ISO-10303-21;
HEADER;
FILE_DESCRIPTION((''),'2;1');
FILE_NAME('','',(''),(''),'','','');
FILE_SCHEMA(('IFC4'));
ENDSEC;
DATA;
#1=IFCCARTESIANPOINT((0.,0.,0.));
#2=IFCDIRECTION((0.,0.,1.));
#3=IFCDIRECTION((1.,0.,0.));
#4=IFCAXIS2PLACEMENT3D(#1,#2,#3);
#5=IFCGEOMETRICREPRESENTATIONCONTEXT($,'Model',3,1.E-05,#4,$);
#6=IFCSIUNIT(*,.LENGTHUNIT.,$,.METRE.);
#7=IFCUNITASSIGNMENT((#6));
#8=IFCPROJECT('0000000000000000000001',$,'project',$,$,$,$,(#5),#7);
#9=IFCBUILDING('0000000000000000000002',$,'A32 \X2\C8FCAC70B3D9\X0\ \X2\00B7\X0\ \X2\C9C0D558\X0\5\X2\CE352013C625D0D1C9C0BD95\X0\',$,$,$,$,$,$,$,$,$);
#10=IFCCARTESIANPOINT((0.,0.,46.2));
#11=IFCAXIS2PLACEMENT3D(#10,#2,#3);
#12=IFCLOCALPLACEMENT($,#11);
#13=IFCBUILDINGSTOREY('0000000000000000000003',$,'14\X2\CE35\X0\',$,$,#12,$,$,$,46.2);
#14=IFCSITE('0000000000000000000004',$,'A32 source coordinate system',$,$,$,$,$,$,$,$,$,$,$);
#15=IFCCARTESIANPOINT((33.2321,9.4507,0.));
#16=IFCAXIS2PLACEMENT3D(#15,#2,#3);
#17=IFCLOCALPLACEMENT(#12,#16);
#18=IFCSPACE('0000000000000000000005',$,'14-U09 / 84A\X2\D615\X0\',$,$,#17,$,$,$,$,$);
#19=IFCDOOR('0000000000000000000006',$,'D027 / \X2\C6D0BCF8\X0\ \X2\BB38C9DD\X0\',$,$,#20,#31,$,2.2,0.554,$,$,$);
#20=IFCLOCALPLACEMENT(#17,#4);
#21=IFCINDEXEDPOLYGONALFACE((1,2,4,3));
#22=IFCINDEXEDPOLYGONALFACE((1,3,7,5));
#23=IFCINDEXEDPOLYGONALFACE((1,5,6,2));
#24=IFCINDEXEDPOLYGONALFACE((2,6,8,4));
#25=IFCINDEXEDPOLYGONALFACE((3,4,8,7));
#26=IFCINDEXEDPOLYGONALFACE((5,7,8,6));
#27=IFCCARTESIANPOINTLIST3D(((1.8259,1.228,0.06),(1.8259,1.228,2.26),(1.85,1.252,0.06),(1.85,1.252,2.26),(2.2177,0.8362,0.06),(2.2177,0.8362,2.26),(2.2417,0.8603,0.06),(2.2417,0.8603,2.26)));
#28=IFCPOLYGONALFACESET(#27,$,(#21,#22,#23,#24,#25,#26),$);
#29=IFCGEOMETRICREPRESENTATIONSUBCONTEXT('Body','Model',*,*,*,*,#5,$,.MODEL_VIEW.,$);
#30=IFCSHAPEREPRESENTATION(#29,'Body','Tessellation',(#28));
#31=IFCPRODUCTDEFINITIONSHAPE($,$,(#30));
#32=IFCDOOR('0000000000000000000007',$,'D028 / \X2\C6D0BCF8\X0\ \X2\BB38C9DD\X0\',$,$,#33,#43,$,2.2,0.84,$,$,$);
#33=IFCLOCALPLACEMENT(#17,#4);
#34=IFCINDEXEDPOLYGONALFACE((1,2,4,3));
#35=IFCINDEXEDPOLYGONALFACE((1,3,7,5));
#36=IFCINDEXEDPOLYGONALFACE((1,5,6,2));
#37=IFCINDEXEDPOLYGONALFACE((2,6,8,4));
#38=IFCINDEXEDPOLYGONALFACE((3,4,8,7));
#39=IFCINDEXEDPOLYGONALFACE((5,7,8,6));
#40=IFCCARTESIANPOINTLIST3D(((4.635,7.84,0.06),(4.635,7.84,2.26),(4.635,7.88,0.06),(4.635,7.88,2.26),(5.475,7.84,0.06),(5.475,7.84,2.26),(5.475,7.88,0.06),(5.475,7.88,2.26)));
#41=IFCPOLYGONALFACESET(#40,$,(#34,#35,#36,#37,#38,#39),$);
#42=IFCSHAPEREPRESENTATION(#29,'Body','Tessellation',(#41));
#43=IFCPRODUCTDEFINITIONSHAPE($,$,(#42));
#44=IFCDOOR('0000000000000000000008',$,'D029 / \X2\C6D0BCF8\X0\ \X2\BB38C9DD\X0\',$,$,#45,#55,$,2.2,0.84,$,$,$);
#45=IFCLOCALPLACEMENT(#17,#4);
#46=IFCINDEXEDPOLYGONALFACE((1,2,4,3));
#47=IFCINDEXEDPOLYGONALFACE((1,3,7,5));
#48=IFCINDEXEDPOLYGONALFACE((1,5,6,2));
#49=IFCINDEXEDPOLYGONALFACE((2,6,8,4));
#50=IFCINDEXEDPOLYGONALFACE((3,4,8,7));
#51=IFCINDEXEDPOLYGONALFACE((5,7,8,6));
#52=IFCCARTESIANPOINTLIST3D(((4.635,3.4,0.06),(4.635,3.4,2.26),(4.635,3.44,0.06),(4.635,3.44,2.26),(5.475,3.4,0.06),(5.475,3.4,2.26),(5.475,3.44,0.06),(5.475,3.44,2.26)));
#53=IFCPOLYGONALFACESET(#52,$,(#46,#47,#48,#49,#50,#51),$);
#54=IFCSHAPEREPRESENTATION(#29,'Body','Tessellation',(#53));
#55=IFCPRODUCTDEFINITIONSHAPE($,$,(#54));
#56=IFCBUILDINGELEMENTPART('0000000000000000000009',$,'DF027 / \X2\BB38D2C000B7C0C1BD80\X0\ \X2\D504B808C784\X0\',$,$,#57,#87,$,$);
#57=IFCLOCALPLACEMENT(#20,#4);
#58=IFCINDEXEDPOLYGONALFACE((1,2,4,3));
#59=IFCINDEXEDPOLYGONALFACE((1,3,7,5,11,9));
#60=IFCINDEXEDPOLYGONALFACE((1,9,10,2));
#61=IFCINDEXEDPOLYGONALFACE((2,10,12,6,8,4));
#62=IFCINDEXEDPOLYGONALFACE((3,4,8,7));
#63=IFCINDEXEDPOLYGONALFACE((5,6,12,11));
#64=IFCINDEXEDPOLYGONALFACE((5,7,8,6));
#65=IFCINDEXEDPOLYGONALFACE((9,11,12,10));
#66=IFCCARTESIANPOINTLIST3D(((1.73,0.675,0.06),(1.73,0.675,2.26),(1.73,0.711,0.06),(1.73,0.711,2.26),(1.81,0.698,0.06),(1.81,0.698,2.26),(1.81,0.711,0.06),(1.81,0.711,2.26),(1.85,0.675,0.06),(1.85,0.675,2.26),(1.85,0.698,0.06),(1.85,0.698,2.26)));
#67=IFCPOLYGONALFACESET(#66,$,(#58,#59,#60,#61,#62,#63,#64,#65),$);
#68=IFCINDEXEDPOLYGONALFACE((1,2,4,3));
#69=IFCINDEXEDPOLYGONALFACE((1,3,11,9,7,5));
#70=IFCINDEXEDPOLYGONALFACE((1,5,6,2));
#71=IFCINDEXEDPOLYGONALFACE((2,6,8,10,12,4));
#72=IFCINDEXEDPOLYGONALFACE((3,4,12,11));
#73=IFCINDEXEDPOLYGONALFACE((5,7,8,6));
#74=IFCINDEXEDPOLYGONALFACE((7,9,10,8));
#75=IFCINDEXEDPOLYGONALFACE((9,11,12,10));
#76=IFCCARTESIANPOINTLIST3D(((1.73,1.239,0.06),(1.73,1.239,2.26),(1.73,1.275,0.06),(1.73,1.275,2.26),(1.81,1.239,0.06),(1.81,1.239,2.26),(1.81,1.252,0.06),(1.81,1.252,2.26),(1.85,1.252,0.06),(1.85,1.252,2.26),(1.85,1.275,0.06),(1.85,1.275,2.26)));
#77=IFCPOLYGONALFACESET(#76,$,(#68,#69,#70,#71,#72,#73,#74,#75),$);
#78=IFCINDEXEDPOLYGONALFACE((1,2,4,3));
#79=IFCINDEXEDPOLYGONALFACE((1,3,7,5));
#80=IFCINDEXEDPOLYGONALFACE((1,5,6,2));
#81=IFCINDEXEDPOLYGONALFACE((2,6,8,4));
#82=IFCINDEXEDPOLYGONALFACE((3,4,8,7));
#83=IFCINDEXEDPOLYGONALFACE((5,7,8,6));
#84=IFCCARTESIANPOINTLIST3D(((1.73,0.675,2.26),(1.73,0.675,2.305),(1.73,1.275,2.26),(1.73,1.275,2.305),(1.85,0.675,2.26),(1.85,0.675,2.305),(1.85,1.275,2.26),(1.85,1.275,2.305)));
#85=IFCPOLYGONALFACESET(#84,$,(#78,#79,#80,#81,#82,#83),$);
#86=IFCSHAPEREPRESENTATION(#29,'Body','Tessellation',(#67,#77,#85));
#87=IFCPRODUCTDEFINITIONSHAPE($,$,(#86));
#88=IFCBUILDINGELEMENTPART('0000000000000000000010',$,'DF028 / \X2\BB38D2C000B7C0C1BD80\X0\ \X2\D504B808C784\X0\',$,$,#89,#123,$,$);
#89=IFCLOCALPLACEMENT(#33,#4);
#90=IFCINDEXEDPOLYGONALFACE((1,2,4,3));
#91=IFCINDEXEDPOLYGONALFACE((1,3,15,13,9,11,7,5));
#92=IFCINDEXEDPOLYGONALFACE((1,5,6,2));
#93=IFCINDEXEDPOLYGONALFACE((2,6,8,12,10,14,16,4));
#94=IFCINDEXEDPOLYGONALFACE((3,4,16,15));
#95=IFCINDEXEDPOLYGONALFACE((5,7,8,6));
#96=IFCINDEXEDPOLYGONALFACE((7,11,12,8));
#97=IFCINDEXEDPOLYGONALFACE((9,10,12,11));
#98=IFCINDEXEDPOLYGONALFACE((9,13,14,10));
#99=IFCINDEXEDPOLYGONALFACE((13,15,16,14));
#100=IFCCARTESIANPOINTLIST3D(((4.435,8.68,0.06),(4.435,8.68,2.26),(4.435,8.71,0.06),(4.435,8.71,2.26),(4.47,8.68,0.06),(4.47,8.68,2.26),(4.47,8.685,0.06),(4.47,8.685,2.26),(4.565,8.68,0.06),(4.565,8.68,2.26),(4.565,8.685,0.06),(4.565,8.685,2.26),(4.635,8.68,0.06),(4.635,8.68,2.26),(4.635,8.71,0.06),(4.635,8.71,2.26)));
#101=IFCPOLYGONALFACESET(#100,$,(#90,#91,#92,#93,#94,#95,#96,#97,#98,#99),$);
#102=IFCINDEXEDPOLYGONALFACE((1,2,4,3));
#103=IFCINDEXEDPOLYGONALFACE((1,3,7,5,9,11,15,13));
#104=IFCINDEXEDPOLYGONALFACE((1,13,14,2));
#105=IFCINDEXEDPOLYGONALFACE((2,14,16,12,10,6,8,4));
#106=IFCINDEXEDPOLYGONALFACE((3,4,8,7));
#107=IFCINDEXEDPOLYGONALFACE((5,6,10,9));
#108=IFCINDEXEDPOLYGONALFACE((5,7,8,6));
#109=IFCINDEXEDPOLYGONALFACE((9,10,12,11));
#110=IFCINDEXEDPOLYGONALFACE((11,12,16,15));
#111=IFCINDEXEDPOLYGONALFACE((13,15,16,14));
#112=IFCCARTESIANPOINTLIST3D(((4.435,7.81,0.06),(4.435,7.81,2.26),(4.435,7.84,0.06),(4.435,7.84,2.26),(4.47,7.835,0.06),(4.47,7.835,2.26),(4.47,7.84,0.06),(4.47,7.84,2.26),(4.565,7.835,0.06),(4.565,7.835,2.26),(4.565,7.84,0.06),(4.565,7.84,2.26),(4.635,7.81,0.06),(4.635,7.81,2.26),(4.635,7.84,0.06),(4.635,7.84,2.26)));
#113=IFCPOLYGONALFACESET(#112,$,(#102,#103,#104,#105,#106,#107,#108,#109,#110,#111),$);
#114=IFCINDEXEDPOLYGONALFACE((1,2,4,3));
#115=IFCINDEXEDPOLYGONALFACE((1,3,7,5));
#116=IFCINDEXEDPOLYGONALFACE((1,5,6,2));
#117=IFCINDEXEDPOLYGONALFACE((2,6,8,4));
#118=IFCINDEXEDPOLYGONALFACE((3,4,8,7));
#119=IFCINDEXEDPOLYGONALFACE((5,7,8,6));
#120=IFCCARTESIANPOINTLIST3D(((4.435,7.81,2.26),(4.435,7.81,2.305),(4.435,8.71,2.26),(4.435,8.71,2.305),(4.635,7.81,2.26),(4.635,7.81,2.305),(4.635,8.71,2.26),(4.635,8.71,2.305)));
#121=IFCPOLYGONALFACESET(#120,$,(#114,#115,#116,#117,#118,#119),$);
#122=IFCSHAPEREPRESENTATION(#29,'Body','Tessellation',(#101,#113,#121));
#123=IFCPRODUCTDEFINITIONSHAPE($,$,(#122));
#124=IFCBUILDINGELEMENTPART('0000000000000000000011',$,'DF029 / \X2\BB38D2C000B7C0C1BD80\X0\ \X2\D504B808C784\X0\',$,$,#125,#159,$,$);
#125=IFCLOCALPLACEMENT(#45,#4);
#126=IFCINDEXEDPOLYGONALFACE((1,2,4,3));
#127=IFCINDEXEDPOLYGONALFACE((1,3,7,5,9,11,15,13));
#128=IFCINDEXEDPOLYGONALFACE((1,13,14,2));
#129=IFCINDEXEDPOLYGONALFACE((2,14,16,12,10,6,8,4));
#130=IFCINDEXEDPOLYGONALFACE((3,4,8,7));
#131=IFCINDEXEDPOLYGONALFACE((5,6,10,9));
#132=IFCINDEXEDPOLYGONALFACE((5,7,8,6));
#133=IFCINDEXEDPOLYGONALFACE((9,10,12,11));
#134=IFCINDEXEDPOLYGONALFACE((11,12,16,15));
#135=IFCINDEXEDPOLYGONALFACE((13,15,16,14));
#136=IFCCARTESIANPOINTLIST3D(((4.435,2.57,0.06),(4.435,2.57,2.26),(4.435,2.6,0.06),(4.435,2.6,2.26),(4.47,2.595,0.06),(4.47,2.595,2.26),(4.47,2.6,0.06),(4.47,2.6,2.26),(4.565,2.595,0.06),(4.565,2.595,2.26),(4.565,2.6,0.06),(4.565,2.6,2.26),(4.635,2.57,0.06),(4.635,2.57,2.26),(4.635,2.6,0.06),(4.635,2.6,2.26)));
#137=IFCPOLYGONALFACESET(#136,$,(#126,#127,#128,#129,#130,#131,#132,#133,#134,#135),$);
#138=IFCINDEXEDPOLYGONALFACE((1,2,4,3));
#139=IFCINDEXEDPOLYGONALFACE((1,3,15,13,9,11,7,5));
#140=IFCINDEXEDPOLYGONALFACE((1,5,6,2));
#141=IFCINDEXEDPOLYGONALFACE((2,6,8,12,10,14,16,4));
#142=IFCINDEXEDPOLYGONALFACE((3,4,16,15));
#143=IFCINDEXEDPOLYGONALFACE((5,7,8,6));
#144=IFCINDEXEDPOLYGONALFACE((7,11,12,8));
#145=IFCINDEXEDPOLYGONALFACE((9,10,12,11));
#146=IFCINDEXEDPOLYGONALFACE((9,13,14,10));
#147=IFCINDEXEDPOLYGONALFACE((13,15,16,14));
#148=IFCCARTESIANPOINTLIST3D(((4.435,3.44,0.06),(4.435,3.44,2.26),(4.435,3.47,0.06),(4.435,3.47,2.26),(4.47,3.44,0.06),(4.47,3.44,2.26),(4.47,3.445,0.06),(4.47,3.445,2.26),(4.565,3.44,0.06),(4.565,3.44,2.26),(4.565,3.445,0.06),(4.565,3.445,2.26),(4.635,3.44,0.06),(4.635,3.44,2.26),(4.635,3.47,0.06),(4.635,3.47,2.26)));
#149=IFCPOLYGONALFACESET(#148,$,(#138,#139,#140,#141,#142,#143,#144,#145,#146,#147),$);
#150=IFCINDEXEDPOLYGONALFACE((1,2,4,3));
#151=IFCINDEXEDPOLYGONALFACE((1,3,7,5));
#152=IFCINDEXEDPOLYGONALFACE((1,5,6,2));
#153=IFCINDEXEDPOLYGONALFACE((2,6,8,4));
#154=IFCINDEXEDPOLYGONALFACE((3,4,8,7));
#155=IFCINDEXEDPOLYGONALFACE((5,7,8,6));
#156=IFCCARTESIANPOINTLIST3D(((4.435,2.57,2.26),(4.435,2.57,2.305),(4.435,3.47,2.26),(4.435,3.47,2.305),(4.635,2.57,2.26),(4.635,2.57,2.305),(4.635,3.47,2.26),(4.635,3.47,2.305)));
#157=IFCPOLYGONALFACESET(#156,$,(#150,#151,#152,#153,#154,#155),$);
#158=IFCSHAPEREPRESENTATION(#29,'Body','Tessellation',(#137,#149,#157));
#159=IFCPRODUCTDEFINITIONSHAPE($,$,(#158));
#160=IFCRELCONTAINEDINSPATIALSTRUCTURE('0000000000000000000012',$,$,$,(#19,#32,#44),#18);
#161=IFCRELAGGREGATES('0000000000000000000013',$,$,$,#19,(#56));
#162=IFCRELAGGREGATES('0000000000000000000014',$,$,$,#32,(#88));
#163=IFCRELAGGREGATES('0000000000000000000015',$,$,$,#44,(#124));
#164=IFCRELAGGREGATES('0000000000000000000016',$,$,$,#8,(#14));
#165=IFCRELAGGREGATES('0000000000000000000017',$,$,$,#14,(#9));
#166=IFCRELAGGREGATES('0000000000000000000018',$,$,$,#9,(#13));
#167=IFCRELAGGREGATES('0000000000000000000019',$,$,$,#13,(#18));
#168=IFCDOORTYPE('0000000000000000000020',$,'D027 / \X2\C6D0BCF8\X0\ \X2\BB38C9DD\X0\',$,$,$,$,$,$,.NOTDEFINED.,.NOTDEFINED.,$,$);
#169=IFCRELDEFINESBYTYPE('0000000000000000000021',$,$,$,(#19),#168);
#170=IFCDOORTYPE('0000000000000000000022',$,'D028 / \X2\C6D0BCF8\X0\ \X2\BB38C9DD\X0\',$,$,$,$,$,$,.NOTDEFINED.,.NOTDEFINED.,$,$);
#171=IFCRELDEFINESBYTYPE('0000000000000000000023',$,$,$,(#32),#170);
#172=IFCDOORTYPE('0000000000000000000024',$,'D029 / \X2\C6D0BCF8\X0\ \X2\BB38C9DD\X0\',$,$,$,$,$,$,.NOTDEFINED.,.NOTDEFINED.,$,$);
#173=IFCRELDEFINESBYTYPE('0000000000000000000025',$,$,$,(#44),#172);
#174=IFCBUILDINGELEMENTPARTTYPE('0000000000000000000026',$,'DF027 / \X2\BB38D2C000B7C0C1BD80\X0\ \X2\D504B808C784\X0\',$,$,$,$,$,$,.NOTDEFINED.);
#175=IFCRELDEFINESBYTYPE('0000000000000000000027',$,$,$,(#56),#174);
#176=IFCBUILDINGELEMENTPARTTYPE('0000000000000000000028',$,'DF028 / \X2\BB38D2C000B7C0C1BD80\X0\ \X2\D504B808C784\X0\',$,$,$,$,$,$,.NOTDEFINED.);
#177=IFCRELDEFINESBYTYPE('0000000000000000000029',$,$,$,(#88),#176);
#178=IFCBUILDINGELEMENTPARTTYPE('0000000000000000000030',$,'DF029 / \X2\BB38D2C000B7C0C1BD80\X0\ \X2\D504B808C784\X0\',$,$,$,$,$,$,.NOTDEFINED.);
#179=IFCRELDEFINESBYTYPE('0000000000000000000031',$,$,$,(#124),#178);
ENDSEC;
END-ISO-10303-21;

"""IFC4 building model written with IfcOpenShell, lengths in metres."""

from ifc_helpers import new_model, si_unit, frame, origin, origin_with_axes, place, context, subcontext, project, spatial, polyline, outline, extrude, source, transform, mapped, type_object, type_shapes, element, aggregate, save


model = new_model("IFC4")

# Units and contexts
model_context = context("Model", 3, precision=1e-05, world=origin_with_axes())
body_context = subcontext(model_context, "Body", "Model", "MODEL_VIEW")
ifc_project = project(units=[si_unit("LENGTHUNIT", "METRE")], contexts=[model_context])

# Site, building, storey, space
storey_placement = place(None, frame((0.0, 0.0, 46.2), z_axis=(0.0, 0.0, 1.0), x_axis=(1.0, 0.0, 0.0)))
space_placement = place(storey_placement, frame((33.2321, 9.4507, 0.0), z_axis=(0.0, 0.0, 1.0), x_axis=(1.0, 0.0, 0.0)))
site = spatial("IfcSite", under=ifc_project, Name="A32 source coordinate system")
building = spatial("IfcBuilding", under=site, Name="A32 주거동 · 지하5층–옥탑지붕")
storey = spatial("IfcBuildingStorey", under=building, at=storey_placement, Name="14층", Elevation=46.2)
space = spatial("IfcSpace", under=storey, at=space_placement, Name="14-U09 / 84A형")

# Doors
door_type_1 = type_object("IfcDoorType", Name="D027 / 원본 문짝", OperationType="NOTDEFINED", PredefinedType="NOTDEFINED")
shared_shape_1 = source(origin(), body_context, "Body", "SweptSolid", [
    extrude(outline(polyline([(1.85, 1.252), (2.2417, 0.8603), (2.2177, 0.8362), (1.8259, 1.228), (1.85, 1.252)])), frame((0.0, 0.0, 0.06)), (0.0, 0.0, 1.0), 2.2),
])
type_shapes(door_type_1, [shared_shape_1])
door_1_placement = place(space_placement, origin_with_axes())
door_1 = element("IfcDoor", 1, at=door_1_placement, inside=space, type_object=door_type_1, Name="D027 / 원본 문짝", OverallHeight=2.2, OverallWidth=0.554, context=body_context, shape_type="MappedRepresentation", body=[
    mapped(shared_shape_1, transform((0.0, 0.0, 0.0), scale=1.0)),
])
door_type_2 = type_object("IfcDoorType", Name="D028 / 원본 문짝", OperationType="NOTDEFINED", PredefinedType="NOTDEFINED")
shared_shape_2 = source(origin(), body_context, "Body", "SweptSolid", [
    extrude(outline(polyline([(5.475, 7.88), (5.475, 7.84), (4.635, 7.84), (4.635, 7.88), (5.475, 7.88)])), frame((0.0, 0.0, 0.06)), (0.0, 0.0, 1.0), 2.2),
])
type_shapes(door_type_2, [shared_shape_2])
door_2_placement = place(space_placement, origin_with_axes())
door_2 = element("IfcDoor", 2, at=door_2_placement, inside=space, type_object=door_type_2, Name="D028 / 원본 문짝", OverallHeight=2.2, OverallWidth=0.84, context=body_context, shape_type="MappedRepresentation", body=[
    mapped(shared_shape_2, transform((0.0, 0.0, 0.0), scale=1.0)),
])
door_type_3 = type_object("IfcDoorType", Name="D029 / 원본 문짝", OperationType="NOTDEFINED", PredefinedType="NOTDEFINED")
shared_shape_3 = source(origin(), body_context, "Body", "SweptSolid", [
    extrude(outline(polyline([(4.635, 3.44), (5.475, 3.44), (5.475, 3.4), (4.635, 3.4), (4.635, 3.44)])), frame((0.0, 0.0, 0.06)), (0.0, 0.0, 1.0), 2.2),
])
type_shapes(door_type_3, [shared_shape_3])
door_3_placement = place(space_placement, origin_with_axes())
door_3 = element("IfcDoor", 3, at=door_3_placement, inside=space, type_object=door_type_3, Name="D029 / 원본 문짝", OverallHeight=2.2, OverallWidth=0.84, context=body_context, shape_type="MappedRepresentation", body=[
    mapped(shared_shape_3, transform((0.0, 0.0, 0.0), scale=1.0)),
])

# Building element parts
building_element_part_type_1 = type_object("IfcBuildingElementPartType", Name="DF027 / 문틀·상부 프레임", PredefinedType="NOTDEFINED")
shared_shape_4 = source(origin(), body_context, "Body", "SweptSolid", [
    extrude(outline(polyline([(1.73, 0.711), (1.81, 0.711), (1.81, 0.698), (1.85, 0.698), (1.85, 0.675), (1.73, 0.675), (1.73, 0.711)])), frame((0.0, 0.0, 0.06)), (0.0, 0.0, 1.0), 2.2),
    extrude(outline(polyline([(1.85, 1.275), (1.85, 1.252), (1.81, 1.252), (1.81, 1.239), (1.73, 1.239), (1.73, 1.275), (1.85, 1.275)])), frame((0.0, 0.0, 0.06)), (0.0, 0.0, 1.0), 2.2),
    extrude(outline(polyline([(1.73, 0.675), (1.73, 1.275), (1.85, 1.275), (1.85, 0.675), (1.73, 0.675)])), frame((0.0, 0.0, 2.26)), (0.0, 0.0, 1.0), 0.045),
])
type_shapes(building_element_part_type_1, [shared_shape_4])
building_element_part_1_placement = place(door_1_placement, origin_with_axes())
building_element_part_1 = element("IfcBuildingElementPart", 4, at=building_element_part_1_placement, type_object=building_element_part_type_1, Name="DF027 / 문틀·상부 프레임", context=body_context, shape_type="MappedRepresentation", body=[
    mapped(shared_shape_4, transform((0.0, 0.0, 0.0), scale=1.0)),
])
aggregate(door_1, [building_element_part_1])
building_element_part_type_2 = type_object("IfcBuildingElementPartType", Name="DF028 / 문틀·상부 프레임", PredefinedType="NOTDEFINED")
shared_shape_5 = source(origin(), body_context, "Body", "SweptSolid", [
    extrude(outline(polyline([(4.635, 8.68), (4.565, 8.68), (4.565, 8.685), (4.47, 8.685), (4.47, 8.68), (4.435, 8.68), (4.435, 8.71), (4.635, 8.71), (4.635, 8.68)])), frame((0.0, 0.0, 0.06)), (0.0, 0.0, 1.0), 2.2),
    extrude(outline(polyline([(4.435, 7.81), (4.435, 7.84), (4.47, 7.84), (4.47, 7.835), (4.565, 7.835), (4.565, 7.84), (4.635, 7.84), (4.635, 7.81), (4.435, 7.81)])), frame((0.0, 0.0, 0.06)), (0.0, 0.0, 1.0), 2.2),
    extrude(outline(polyline([(4.435, 7.81), (4.435, 8.71), (4.635, 8.71), (4.635, 7.81), (4.435, 7.81)])), frame((0.0, 0.0, 2.26)), (0.0, 0.0, 1.0), 0.045),
])
type_shapes(building_element_part_type_2, [shared_shape_5])
building_element_part_2_placement = place(door_2_placement, origin_with_axes())
building_element_part_2 = element("IfcBuildingElementPart", 5, at=building_element_part_2_placement, type_object=building_element_part_type_2, Name="DF028 / 문틀·상부 프레임", context=body_context, shape_type="MappedRepresentation", body=[
    mapped(shared_shape_5, transform((0.0, 0.0, 0.0), scale=1.0)),
])
aggregate(door_2, [building_element_part_2])
building_element_part_type_3 = type_object("IfcBuildingElementPartType", Name="DF029 / 문틀·상부 프레임", PredefinedType="NOTDEFINED")
shared_shape_6 = source(origin(), body_context, "Body", "SweptSolid", [
    extrude(outline(polyline([(4.435, 2.57), (4.435, 2.6), (4.47, 2.6), (4.47, 2.595), (4.565, 2.595), (4.565, 2.6), (4.635, 2.6), (4.635, 2.57), (4.435, 2.57)])), frame((0.0, 0.0, 0.06)), (0.0, 0.0, 1.0), 2.2),
    extrude(outline(polyline([(4.635, 3.44), (4.565, 3.44), (4.565, 3.445), (4.47, 3.445), (4.47, 3.44), (4.435, 3.44), (4.435, 3.47), (4.635, 3.47), (4.635, 3.44)])), frame((0.0, 0.0, 0.06)), (0.0, 0.0, 1.0), 2.2),
    extrude(outline(polyline([(4.435, 2.57), (4.435, 3.47), (4.635, 3.47), (4.635, 2.57), (4.435, 2.57)])), frame((0.0, 0.0, 2.26)), (0.0, 0.0, 1.0), 0.045),
])
type_shapes(building_element_part_type_3, [shared_shape_6])
building_element_part_3_placement = place(door_3_placement, origin_with_axes())
building_element_part_3 = element("IfcBuildingElementPart", 6, at=building_element_part_3_placement, type_object=building_element_part_type_3, Name="DF029 / 문틀·상부 프레임", context=body_context, shape_type="MappedRepresentation", body=[
    mapped(shared_shape_6, transform((0.0, 0.0, 0.0), scale=1.0)),
])
aggregate(door_3, [building_element_part_3])

save(model, "model.ifc")
